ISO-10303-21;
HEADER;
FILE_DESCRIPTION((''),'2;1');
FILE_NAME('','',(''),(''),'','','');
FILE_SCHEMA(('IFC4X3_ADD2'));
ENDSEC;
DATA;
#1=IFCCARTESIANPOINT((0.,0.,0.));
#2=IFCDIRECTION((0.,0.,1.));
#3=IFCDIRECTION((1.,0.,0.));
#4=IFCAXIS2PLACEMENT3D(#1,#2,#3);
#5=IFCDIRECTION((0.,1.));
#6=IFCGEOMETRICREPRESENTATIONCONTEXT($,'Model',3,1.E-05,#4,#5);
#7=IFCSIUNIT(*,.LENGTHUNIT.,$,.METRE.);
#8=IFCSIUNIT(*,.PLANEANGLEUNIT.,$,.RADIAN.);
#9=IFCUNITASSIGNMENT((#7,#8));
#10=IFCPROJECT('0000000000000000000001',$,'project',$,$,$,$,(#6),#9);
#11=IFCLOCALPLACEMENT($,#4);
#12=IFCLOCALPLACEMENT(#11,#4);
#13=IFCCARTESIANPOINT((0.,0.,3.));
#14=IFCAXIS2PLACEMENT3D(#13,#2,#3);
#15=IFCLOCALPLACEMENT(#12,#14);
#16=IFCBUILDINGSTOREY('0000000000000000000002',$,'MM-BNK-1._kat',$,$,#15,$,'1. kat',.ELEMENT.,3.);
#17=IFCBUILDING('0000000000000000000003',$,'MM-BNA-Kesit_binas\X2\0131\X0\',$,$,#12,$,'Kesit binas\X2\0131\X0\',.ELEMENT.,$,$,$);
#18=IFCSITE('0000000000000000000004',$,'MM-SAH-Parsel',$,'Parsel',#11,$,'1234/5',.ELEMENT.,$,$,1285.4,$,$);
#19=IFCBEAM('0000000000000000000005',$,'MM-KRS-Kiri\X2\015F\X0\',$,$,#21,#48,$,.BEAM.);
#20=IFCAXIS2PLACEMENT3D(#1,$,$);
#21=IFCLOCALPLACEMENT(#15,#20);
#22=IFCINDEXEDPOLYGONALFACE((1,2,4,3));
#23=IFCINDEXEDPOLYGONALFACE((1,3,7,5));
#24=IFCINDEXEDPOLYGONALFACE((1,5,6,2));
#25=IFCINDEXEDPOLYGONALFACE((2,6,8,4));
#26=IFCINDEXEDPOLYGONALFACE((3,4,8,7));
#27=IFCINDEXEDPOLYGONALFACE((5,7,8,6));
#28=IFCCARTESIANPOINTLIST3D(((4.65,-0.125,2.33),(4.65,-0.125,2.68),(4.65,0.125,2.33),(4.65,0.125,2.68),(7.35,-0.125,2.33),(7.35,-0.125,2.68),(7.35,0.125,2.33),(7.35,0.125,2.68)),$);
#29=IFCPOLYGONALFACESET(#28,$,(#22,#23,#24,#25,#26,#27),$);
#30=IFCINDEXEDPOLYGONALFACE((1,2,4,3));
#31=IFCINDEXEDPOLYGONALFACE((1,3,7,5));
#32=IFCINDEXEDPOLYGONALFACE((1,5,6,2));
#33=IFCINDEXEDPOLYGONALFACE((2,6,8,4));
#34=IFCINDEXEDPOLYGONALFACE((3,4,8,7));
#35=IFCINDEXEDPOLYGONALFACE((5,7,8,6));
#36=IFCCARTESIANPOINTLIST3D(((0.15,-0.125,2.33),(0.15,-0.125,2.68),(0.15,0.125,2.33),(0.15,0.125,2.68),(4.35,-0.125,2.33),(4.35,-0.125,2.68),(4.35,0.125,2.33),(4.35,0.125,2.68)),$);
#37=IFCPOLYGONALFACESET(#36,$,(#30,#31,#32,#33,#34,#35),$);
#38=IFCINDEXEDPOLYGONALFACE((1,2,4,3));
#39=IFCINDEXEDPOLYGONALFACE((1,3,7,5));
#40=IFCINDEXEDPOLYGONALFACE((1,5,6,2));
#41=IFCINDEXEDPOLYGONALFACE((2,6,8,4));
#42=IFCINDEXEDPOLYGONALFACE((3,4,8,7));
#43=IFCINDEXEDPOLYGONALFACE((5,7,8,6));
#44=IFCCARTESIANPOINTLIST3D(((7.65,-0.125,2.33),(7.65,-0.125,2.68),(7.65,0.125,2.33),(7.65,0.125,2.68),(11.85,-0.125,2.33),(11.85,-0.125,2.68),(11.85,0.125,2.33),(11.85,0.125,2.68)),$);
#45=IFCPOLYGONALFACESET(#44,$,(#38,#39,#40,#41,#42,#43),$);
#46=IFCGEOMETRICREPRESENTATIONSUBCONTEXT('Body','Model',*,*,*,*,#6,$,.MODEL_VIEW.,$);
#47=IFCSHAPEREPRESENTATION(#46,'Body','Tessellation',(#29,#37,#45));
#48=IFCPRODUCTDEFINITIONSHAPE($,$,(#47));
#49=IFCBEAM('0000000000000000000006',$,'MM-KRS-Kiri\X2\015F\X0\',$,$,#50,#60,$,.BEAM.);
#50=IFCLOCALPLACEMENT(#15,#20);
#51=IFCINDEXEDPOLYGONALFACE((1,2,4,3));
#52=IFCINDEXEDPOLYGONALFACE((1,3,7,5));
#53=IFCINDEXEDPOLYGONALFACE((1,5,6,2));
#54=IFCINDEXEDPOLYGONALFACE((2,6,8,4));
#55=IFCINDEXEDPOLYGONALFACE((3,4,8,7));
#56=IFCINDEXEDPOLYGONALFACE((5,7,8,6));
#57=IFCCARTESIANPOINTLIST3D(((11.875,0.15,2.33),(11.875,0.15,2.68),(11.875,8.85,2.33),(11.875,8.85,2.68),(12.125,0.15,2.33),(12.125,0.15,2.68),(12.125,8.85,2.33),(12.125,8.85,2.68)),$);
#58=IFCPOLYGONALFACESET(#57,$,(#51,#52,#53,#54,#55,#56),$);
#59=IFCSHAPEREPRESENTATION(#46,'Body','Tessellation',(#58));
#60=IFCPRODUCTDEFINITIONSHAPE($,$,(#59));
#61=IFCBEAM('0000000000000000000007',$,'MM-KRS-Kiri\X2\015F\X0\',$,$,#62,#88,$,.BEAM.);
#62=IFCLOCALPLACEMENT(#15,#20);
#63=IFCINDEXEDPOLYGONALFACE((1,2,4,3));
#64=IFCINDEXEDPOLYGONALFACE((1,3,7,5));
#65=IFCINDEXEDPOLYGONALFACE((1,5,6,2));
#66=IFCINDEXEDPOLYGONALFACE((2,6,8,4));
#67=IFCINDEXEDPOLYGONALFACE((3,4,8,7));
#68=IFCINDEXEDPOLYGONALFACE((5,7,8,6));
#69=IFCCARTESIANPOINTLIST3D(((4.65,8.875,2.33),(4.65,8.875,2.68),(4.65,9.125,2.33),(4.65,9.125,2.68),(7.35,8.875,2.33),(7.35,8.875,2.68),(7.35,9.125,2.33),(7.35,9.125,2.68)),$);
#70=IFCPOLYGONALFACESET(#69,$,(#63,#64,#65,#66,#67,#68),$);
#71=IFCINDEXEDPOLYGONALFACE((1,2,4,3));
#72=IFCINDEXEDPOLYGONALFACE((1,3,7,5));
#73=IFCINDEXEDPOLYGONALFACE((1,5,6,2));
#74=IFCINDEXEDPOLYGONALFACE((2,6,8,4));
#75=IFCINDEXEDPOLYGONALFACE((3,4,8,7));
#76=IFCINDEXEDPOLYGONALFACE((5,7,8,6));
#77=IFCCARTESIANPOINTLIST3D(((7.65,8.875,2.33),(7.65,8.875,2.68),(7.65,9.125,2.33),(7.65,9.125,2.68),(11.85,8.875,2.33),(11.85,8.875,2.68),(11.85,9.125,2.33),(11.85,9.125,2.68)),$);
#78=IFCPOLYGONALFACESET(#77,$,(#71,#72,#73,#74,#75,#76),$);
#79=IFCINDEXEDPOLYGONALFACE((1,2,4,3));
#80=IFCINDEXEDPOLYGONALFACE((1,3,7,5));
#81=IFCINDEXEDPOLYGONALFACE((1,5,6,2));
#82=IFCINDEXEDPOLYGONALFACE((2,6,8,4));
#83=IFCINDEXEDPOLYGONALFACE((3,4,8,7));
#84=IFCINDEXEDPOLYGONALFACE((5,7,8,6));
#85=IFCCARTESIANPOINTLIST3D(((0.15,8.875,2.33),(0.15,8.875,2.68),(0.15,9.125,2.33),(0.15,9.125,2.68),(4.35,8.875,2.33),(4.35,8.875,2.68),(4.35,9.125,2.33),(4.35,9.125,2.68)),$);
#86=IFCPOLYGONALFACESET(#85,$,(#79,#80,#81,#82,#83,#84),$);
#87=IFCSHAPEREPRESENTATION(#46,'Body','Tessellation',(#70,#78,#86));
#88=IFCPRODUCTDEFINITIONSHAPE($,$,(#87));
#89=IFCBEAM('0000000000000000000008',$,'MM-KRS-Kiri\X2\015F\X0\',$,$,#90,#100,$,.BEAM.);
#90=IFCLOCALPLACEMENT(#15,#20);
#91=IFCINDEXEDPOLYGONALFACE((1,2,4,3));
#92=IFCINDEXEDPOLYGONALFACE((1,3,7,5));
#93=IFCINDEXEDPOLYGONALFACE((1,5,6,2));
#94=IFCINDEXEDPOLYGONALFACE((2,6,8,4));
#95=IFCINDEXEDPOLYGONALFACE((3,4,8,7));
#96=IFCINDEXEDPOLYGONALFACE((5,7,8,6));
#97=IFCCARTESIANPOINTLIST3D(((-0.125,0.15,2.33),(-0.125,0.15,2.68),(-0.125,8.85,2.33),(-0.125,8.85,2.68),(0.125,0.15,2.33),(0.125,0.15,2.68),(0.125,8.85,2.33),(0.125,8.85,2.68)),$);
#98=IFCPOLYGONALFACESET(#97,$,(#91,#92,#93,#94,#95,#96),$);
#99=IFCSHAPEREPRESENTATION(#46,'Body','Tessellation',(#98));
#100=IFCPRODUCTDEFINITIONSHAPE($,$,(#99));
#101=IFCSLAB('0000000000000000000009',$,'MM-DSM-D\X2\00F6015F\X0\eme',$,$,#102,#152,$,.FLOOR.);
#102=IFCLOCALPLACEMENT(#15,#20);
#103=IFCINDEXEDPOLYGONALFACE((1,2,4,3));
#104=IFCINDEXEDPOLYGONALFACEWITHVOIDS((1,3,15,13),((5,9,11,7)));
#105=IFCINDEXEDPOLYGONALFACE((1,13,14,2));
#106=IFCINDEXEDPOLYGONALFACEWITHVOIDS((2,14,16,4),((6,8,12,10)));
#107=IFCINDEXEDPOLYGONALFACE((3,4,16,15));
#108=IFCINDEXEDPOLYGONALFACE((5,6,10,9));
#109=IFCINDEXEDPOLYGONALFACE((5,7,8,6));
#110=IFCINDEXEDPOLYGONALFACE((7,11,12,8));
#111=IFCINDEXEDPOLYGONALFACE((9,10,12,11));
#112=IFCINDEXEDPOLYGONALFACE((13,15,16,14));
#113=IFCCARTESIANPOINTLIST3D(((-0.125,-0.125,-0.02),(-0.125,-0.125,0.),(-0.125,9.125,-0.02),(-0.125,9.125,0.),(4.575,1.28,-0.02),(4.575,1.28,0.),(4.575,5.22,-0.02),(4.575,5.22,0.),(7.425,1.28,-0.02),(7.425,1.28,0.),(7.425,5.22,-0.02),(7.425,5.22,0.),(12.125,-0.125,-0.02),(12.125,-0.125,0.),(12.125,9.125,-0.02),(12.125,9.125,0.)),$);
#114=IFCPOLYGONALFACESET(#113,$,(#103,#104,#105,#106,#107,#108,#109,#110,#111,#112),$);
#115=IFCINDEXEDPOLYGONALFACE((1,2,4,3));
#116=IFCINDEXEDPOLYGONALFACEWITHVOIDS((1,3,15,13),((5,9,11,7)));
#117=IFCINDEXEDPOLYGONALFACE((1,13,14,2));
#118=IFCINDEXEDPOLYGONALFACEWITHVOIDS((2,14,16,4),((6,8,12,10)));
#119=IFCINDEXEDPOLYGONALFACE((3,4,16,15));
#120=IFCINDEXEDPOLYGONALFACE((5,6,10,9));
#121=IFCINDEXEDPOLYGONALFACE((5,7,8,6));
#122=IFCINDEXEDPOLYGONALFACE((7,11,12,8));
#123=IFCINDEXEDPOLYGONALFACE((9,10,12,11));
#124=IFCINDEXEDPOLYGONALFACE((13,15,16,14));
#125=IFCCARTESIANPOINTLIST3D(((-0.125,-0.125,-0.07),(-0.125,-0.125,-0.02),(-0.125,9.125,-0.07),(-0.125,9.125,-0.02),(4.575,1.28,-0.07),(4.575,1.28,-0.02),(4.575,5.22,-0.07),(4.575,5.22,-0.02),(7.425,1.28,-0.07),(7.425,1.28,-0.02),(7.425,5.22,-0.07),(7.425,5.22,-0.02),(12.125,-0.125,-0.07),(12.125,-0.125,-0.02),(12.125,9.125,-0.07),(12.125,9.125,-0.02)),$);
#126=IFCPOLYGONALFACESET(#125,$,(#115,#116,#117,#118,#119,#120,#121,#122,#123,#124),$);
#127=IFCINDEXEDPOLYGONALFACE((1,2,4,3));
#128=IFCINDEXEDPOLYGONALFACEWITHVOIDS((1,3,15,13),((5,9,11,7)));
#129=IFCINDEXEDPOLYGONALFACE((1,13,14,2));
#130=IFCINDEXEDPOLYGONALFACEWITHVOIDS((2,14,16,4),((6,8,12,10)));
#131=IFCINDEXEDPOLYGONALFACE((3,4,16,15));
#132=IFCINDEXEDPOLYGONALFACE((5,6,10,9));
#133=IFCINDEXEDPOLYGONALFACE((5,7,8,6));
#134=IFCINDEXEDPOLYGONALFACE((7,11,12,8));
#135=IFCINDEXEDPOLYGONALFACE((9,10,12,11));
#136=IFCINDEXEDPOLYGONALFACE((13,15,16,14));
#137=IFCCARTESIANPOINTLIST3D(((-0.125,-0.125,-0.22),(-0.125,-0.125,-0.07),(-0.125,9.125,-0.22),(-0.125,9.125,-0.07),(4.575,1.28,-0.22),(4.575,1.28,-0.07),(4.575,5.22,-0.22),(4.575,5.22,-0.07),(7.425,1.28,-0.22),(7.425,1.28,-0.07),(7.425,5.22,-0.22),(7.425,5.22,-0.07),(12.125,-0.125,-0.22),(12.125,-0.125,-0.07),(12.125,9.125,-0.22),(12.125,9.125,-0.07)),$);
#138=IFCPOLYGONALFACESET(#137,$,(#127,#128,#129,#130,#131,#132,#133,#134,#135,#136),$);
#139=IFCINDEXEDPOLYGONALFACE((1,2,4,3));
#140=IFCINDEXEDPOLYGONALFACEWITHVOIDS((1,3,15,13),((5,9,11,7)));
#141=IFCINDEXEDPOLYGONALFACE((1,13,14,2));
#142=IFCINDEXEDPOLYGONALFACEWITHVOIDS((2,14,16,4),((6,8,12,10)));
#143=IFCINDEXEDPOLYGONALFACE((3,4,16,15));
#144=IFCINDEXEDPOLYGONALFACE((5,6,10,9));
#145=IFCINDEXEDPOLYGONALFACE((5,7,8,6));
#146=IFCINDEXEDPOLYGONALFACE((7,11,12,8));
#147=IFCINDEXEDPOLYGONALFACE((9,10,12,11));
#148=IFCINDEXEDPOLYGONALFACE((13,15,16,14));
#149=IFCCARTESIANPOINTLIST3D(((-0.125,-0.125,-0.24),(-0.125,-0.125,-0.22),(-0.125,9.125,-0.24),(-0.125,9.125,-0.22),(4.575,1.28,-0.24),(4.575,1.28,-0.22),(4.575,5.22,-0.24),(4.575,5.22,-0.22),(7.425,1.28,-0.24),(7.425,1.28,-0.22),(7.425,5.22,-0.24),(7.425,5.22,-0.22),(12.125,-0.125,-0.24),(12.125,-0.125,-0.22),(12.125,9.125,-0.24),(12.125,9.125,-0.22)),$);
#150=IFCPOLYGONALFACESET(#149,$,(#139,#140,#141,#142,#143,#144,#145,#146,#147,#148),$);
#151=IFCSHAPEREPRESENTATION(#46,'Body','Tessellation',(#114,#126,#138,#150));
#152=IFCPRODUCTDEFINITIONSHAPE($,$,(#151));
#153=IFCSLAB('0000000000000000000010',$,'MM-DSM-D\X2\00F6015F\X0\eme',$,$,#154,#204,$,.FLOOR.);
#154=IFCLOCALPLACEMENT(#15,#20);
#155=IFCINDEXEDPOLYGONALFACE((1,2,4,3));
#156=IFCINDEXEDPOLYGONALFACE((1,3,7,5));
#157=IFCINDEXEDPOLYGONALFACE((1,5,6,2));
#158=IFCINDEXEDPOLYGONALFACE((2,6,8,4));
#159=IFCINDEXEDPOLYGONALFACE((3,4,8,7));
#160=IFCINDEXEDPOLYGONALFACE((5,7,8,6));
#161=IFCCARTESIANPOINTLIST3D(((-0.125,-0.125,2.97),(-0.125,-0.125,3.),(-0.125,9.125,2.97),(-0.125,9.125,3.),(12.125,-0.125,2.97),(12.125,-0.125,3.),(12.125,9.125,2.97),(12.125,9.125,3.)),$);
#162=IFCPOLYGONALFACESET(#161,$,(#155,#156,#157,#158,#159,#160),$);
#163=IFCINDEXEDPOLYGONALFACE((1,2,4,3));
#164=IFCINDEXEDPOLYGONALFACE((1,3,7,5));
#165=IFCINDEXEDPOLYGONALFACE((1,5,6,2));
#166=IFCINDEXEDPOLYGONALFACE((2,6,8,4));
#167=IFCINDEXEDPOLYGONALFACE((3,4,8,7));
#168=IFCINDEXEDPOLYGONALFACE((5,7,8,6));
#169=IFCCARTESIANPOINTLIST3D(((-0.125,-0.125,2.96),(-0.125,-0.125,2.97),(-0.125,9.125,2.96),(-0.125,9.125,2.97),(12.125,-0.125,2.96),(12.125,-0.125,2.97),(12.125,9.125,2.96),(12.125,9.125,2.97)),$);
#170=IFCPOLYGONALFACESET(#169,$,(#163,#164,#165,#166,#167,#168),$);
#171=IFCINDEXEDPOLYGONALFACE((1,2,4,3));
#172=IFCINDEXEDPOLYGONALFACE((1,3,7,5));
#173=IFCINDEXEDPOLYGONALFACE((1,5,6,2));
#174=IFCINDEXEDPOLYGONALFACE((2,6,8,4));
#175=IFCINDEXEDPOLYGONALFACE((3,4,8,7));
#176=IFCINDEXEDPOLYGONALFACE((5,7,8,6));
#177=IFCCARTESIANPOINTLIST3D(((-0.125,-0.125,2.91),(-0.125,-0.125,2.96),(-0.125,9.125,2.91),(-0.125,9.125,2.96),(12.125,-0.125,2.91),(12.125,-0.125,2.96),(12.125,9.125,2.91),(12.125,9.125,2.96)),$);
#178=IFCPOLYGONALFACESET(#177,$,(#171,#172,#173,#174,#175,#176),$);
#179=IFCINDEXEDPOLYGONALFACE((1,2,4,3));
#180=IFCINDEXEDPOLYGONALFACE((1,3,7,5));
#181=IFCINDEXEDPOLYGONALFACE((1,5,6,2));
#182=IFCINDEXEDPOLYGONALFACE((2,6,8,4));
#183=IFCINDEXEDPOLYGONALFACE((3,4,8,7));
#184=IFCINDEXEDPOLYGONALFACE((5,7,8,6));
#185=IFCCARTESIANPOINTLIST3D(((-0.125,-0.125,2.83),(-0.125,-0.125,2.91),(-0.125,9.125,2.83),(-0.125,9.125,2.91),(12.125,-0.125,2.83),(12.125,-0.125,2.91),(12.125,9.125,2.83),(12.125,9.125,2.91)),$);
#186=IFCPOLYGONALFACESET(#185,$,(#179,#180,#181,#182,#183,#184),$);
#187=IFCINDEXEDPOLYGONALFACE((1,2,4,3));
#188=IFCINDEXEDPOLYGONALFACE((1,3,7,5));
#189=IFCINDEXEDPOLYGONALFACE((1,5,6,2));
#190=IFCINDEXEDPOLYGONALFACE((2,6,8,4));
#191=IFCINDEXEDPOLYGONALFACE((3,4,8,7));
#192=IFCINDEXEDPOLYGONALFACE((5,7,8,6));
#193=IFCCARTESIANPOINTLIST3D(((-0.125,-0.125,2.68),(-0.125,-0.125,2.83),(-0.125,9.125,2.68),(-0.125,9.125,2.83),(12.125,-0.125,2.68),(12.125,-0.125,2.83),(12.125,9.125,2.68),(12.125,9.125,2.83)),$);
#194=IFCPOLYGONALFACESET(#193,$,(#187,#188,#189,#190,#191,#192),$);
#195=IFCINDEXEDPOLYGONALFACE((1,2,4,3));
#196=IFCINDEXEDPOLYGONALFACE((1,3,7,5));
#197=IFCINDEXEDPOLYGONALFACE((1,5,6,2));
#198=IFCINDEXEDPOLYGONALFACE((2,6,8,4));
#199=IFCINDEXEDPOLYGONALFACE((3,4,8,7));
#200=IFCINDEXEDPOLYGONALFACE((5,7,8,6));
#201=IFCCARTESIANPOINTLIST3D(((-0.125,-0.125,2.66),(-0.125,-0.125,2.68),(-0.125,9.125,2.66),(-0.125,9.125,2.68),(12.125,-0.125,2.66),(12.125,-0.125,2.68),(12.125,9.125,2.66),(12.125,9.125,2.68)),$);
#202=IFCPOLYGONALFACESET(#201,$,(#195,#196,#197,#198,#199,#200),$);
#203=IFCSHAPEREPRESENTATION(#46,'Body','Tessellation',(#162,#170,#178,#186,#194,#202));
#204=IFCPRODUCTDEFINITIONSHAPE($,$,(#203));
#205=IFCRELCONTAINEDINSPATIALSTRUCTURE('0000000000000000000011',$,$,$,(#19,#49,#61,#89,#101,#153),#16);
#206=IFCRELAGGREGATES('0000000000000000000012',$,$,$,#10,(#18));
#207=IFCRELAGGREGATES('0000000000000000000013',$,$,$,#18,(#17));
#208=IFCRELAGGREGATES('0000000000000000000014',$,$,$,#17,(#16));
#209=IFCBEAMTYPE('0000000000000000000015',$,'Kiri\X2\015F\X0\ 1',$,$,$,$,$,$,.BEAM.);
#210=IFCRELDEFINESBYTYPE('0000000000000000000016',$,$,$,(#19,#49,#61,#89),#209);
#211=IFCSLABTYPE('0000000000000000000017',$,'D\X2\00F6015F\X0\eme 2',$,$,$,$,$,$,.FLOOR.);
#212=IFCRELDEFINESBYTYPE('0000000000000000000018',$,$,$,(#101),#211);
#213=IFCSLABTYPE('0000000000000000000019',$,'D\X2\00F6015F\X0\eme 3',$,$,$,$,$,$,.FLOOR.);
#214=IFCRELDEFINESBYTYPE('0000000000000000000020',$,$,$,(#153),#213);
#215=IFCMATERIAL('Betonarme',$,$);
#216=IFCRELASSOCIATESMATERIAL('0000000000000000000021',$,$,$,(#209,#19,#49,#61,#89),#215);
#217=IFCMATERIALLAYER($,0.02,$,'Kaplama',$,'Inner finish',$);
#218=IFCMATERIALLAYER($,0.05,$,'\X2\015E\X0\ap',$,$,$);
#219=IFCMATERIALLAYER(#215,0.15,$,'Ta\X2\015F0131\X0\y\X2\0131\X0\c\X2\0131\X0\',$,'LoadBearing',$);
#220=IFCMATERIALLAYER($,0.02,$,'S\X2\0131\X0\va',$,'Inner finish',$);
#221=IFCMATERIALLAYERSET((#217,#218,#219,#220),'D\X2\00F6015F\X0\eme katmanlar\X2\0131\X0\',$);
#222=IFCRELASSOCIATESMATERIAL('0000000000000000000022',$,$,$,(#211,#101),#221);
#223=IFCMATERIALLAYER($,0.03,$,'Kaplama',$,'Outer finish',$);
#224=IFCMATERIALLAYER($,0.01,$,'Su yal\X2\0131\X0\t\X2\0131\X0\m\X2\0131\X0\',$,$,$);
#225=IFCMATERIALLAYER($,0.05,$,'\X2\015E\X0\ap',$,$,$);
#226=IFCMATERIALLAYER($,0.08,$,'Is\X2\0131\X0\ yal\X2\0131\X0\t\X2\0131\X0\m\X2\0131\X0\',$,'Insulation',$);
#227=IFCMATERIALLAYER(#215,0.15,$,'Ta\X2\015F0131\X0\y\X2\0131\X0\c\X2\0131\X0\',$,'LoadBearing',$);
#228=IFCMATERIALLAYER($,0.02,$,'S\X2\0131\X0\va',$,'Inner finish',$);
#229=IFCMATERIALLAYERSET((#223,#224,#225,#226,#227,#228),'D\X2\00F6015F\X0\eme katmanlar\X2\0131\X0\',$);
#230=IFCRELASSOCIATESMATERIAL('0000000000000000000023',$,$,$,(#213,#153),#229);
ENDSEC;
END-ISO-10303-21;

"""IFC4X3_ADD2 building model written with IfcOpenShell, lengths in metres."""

from ifc_helpers import new_model, si_unit, direction, frame, origin_with_axes, place, context, subcontext, project, spatial, polyline, rectangle, outline, extrude, material, layer, layer_set, layer_usage, material_profile, profile_set, type_object, element, save


model = new_model("IFC4X3_ADD2")

# Units and contexts
model_context = context("Model", 3, precision=1e-05, world=origin_with_axes(), true_north=direction((0.0, 1.0)))
body_context = subcontext(model_context, "Body", "Model", "MODEL_VIEW")
ifc_project = project(units=[si_unit("LENGTHUNIT", "METRE"), si_unit("PLANEANGLEUNIT", "RADIAN")], contexts=[model_context])

# Site, building, storey
site_placement = place(None, origin_with_axes())
site = spatial("IfcSite", under=ifc_project, at=site_placement, Name="MM-SAH-Parsel", ObjectType="Parsel", LongName="1234/5", CompositionType="ELEMENT", RefElevation=1285.4)
building_placement = place(site_placement, origin_with_axes())
building = spatial("IfcBuilding", under=site, at=building_placement, Name="MM-BNA-Kesit_binası", LongName="Kesit binası", CompositionType="ELEMENT")
storey_placement = place(building_placement, frame((0.0, 0.0, 3.0), z_axis=(0.0, 0.0, 1.0), x_axis=(1.0, 0.0, 0.0)))
storey = spatial("IfcBuildingStorey", under=building, at=storey_placement, Name="MM-BNK-1._kat", LongName="1. kat", CompositionType="ELEMENT", Elevation=3.0)

# Shared definitions
ifc_material_1 = material(Name="Betonarme")

# Beams
ifc_material_profile_1 = material_profile(ifc_material_1, rectangle(XDim=0.25, YDim=0.5), Category="LoadBearing")
ifc_profile_set_1 = profile_set([ifc_material_profile_1], Name="Kiriş 1")
beam_type = type_object("IfcBeamType", Name="Kiriş 1", PredefinedType="BEAM", material=ifc_profile_set_1)
beam_1_placement = place(storey_placement, origin_with_axes())
element("IfcBeam", 1, at=beam_1_placement, inside=storey, type_object=beam_type, material=ifc_material_1, Name="MM-KRS-Kiriş", PredefinedType="BEAM", context=body_context, shape_type="SweptSolid", body=[
    extrude(outline(polyline([(4.65, -0.125), (7.35, -0.125), (7.35, 0.125), (4.65, 0.125), (4.65, -0.125)])), frame((0.0, 0.0, 2.33)), (0.0, 0.0, 1.0), 0.35),
    extrude(outline(polyline([(0.15, -0.125), (4.35, -0.125), (4.35, 0.125), (0.15, 0.125), (0.15, -0.125)])), frame((0.0, 0.0, 2.33)), (0.0, 0.0, 1.0), 0.35),
    extrude(outline(polyline([(7.65, -0.125), (11.85, -0.125), (11.85, 0.125), (7.65, 0.125), (7.65, -0.125)])), frame((0.0, 0.0, 2.33)), (0.0, 0.0, 1.0), 0.35),
])
beam_2_placement = place(storey_placement, origin_with_axes())
element("IfcBeam", 2, at=beam_2_placement, inside=storey, type_object=beam_type, material=ifc_material_1, Name="MM-KRS-Kiriş", PredefinedType="BEAM", context=body_context, shape_type="SweptSolid", body=[
    extrude(outline(polyline([(12.125, 0.15), (12.125, 8.85), (11.875, 8.85), (11.875, 0.15), (12.125, 0.15)])), frame((0.0, 0.0, 2.33)), (0.0, 0.0, 1.0), 0.35),
])
beam_3_placement = place(storey_placement, origin_with_axes())
element("IfcBeam", 3, at=beam_3_placement, inside=storey, type_object=beam_type, material=ifc_material_1, Name="MM-KRS-Kiriş", PredefinedType="BEAM", context=body_context, shape_type="SweptSolid", body=[
    extrude(outline(polyline([(7.35, 9.125), (4.65, 9.125), (4.65, 8.875), (7.35, 8.875), (7.35, 9.125)])), frame((0.0, 0.0, 2.33)), (0.0, 0.0, 1.0), 0.35),
    extrude(outline(polyline([(11.85, 9.125), (7.65, 9.125), (7.65, 8.875), (11.85, 8.875), (11.85, 9.125)])), frame((0.0, 0.0, 2.33)), (0.0, 0.0, 1.0), 0.35),
    extrude(outline(polyline([(4.35, 9.125), (0.15, 9.125), (0.15, 8.875), (4.35, 8.875), (4.35, 9.125)])), frame((0.0, 0.0, 2.33)), (0.0, 0.0, 1.0), 0.35),
])
beam_4_placement = place(storey_placement, origin_with_axes())
element("IfcBeam", 4, at=beam_4_placement, inside=storey, type_object=beam_type, material=ifc_material_1, Name="MM-KRS-Kiriş", PredefinedType="BEAM", context=body_context, shape_type="SweptSolid", body=[
    extrude(outline(polyline([(-0.125, 8.85), (-0.125, 0.15), (0.125, 0.15), (0.125, 8.85), (-0.125, 8.85)])), frame((0.0, 0.0, 2.33)), (0.0, 0.0, 1.0), 0.35),
])

# Slab, opening
ifc_layer_1 = layer(None, 0.02, Name="Kaplama", Category="Inner finish")
ifc_layer_2 = layer(None, 0.05, Name="Şap")
ifc_layer_3 = layer(ifc_material_1, 0.15, Name="Taşıyıcı", Category="LoadBearing")
ifc_layer_4 = layer(None, 0.02, Name="Sıva", Category="Inner finish")
ifc_layer_set_1 = layer_set([ifc_layer_1, ifc_layer_2, ifc_layer_3, ifc_layer_4], Name="Döşeme katmanları")
ifc_layer_usage_1 = layer_usage(ifc_layer_set_1, "AXIS3", "NEGATIVE", 0.0)
slab_type_1 = type_object("IfcSlabType", Name="Döşeme 2", PredefinedType="FLOOR", material=ifc_layer_set_1)
slab_1_placement = place(storey_placement, origin_with_axes())
slab_1 = element("IfcSlab", 5, at=slab_1_placement, inside=storey, type_object=slab_type_1, material=ifc_layer_usage_1, Name="MM-DSM-Döşeme", PredefinedType="FLOOR", context=body_context, shape_type="SweptSolid", body=[
    extrude(outline(polyline([(-0.125, -0.125), (12.125, -0.125), (12.125, 9.125), (-0.125, 9.125), (-0.125, -0.125)])), frame((0.0, 0.0, -0.02)), (0.0, 0.0, 1.0), 0.02),
    extrude(outline(polyline([(-0.125, -0.125), (12.125, -0.125), (12.125, 9.125), (-0.125, 9.125), (-0.125, -0.125)])), frame((0.0, 0.0, -0.07)), (0.0, 0.0, 1.0), 0.05),
    extrude(outline(polyline([(-0.125, -0.125), (12.125, -0.125), (12.125, 9.125), (-0.125, 9.125), (-0.125, -0.125)])), frame((0.0, 0.0, -0.22)), (0.0, 0.0, 1.0), 0.15),
    extrude(outline(polyline([(-0.125, -0.125), (12.125, -0.125), (12.125, 9.125), (-0.125, 9.125), (-0.125, -0.125)])), frame((0.0, 0.0, -0.24)), (0.0, 0.0, 1.0), 0.02),
])
opening_1_placement = place(storey_placement, origin_with_axes())
element("IfcOpeningElement", 6, at=opening_1_placement, cuts=slab_1, PredefinedType="OPENING", context=body_context, shape_type="SweptSolid", body=[
    extrude(outline(polyline([(4.575, 1.28), (4.575, 5.22), (7.425, 5.22), (7.425, 1.28), (4.575, 1.28)])), frame((0.0, 0.0, -0.24)), (0.0, 0.0, 1.0), 0.24),
])

# Slab
ifc_layer_5 = layer(None, 0.03, Name="Kaplama", Category="Outer finish")
ifc_layer_6 = layer(None, 0.01, Name="Su yalıtımı")
ifc_layer_7 = layer(None, 0.05, Name="Şap")
ifc_layer_8 = layer(None, 0.08, Name="Isı yalıtımı", Category="Insulation")
ifc_layer_9 = layer(ifc_material_1, 0.15, Name="Taşıyıcı", Category="LoadBearing")
ifc_layer_10 = layer(None, 0.02, Name="Sıva", Category="Inner finish")
ifc_layer_set_2 = layer_set([ifc_layer_5, ifc_layer_6, ifc_layer_7, ifc_layer_8, ifc_layer_9, ifc_layer_10], Name="Döşeme katmanları")
ifc_layer_usage_2 = layer_usage(ifc_layer_set_2, "AXIS3", "NEGATIVE", 3.0)
slab_type_2 = type_object("IfcSlabType", Name="Döşeme 3", PredefinedType="FLOOR", material=ifc_layer_set_2)
slab_2_placement = place(storey_placement, origin_with_axes())
element("IfcSlab", 7, at=slab_2_placement, inside=storey, type_object=slab_type_2, material=ifc_layer_usage_2, Name="MM-DSM-Döşeme", PredefinedType="FLOOR", context=body_context, shape_type="SweptSolid", body=[
    extrude(outline(polyline([(-0.125, -0.125), (12.125, -0.125), (12.125, 9.125), (-0.125, 9.125), (-0.125, -0.125)])), frame((0.0, 0.0, 2.97)), (0.0, 0.0, 1.0), 0.03),
    extrude(outline(polyline([(-0.125, -0.125), (12.125, -0.125), (12.125, 9.125), (-0.125, 9.125), (-0.125, -0.125)])), frame((0.0, 0.0, 2.96)), (0.0, 0.0, 1.0), 0.01),
    extrude(outline(polyline([(-0.125, -0.125), (12.125, -0.125), (12.125, 9.125), (-0.125, 9.125), (-0.125, -0.125)])), frame((0.0, 0.0, 2.91)), (0.0, 0.0, 1.0), 0.05),
    extrude(outline(polyline([(-0.125, -0.125), (12.125, -0.125), (12.125, 9.125), (-0.125, 9.125), (-0.125, -0.125)])), frame((0.0, 0.0, 2.83)), (0.0, 0.0, 1.0), 0.08),
    extrude(outline(polyline([(-0.125, -0.125), (12.125, -0.125), (12.125, 9.125), (-0.125, 9.125), (-0.125, -0.125)])), frame((0.0, 0.0, 2.68)), (0.0, 0.0, 1.0), 0.15),
    extrude(outline(polyline([(-0.125, -0.125), (12.125, -0.125), (12.125, 9.125), (-0.125, 9.125), (-0.125, -0.125)])), frame((0.0, 0.0, 2.66)), (0.0, 0.0, 1.0), 0.02),
])

save(model, "model.ifc")
